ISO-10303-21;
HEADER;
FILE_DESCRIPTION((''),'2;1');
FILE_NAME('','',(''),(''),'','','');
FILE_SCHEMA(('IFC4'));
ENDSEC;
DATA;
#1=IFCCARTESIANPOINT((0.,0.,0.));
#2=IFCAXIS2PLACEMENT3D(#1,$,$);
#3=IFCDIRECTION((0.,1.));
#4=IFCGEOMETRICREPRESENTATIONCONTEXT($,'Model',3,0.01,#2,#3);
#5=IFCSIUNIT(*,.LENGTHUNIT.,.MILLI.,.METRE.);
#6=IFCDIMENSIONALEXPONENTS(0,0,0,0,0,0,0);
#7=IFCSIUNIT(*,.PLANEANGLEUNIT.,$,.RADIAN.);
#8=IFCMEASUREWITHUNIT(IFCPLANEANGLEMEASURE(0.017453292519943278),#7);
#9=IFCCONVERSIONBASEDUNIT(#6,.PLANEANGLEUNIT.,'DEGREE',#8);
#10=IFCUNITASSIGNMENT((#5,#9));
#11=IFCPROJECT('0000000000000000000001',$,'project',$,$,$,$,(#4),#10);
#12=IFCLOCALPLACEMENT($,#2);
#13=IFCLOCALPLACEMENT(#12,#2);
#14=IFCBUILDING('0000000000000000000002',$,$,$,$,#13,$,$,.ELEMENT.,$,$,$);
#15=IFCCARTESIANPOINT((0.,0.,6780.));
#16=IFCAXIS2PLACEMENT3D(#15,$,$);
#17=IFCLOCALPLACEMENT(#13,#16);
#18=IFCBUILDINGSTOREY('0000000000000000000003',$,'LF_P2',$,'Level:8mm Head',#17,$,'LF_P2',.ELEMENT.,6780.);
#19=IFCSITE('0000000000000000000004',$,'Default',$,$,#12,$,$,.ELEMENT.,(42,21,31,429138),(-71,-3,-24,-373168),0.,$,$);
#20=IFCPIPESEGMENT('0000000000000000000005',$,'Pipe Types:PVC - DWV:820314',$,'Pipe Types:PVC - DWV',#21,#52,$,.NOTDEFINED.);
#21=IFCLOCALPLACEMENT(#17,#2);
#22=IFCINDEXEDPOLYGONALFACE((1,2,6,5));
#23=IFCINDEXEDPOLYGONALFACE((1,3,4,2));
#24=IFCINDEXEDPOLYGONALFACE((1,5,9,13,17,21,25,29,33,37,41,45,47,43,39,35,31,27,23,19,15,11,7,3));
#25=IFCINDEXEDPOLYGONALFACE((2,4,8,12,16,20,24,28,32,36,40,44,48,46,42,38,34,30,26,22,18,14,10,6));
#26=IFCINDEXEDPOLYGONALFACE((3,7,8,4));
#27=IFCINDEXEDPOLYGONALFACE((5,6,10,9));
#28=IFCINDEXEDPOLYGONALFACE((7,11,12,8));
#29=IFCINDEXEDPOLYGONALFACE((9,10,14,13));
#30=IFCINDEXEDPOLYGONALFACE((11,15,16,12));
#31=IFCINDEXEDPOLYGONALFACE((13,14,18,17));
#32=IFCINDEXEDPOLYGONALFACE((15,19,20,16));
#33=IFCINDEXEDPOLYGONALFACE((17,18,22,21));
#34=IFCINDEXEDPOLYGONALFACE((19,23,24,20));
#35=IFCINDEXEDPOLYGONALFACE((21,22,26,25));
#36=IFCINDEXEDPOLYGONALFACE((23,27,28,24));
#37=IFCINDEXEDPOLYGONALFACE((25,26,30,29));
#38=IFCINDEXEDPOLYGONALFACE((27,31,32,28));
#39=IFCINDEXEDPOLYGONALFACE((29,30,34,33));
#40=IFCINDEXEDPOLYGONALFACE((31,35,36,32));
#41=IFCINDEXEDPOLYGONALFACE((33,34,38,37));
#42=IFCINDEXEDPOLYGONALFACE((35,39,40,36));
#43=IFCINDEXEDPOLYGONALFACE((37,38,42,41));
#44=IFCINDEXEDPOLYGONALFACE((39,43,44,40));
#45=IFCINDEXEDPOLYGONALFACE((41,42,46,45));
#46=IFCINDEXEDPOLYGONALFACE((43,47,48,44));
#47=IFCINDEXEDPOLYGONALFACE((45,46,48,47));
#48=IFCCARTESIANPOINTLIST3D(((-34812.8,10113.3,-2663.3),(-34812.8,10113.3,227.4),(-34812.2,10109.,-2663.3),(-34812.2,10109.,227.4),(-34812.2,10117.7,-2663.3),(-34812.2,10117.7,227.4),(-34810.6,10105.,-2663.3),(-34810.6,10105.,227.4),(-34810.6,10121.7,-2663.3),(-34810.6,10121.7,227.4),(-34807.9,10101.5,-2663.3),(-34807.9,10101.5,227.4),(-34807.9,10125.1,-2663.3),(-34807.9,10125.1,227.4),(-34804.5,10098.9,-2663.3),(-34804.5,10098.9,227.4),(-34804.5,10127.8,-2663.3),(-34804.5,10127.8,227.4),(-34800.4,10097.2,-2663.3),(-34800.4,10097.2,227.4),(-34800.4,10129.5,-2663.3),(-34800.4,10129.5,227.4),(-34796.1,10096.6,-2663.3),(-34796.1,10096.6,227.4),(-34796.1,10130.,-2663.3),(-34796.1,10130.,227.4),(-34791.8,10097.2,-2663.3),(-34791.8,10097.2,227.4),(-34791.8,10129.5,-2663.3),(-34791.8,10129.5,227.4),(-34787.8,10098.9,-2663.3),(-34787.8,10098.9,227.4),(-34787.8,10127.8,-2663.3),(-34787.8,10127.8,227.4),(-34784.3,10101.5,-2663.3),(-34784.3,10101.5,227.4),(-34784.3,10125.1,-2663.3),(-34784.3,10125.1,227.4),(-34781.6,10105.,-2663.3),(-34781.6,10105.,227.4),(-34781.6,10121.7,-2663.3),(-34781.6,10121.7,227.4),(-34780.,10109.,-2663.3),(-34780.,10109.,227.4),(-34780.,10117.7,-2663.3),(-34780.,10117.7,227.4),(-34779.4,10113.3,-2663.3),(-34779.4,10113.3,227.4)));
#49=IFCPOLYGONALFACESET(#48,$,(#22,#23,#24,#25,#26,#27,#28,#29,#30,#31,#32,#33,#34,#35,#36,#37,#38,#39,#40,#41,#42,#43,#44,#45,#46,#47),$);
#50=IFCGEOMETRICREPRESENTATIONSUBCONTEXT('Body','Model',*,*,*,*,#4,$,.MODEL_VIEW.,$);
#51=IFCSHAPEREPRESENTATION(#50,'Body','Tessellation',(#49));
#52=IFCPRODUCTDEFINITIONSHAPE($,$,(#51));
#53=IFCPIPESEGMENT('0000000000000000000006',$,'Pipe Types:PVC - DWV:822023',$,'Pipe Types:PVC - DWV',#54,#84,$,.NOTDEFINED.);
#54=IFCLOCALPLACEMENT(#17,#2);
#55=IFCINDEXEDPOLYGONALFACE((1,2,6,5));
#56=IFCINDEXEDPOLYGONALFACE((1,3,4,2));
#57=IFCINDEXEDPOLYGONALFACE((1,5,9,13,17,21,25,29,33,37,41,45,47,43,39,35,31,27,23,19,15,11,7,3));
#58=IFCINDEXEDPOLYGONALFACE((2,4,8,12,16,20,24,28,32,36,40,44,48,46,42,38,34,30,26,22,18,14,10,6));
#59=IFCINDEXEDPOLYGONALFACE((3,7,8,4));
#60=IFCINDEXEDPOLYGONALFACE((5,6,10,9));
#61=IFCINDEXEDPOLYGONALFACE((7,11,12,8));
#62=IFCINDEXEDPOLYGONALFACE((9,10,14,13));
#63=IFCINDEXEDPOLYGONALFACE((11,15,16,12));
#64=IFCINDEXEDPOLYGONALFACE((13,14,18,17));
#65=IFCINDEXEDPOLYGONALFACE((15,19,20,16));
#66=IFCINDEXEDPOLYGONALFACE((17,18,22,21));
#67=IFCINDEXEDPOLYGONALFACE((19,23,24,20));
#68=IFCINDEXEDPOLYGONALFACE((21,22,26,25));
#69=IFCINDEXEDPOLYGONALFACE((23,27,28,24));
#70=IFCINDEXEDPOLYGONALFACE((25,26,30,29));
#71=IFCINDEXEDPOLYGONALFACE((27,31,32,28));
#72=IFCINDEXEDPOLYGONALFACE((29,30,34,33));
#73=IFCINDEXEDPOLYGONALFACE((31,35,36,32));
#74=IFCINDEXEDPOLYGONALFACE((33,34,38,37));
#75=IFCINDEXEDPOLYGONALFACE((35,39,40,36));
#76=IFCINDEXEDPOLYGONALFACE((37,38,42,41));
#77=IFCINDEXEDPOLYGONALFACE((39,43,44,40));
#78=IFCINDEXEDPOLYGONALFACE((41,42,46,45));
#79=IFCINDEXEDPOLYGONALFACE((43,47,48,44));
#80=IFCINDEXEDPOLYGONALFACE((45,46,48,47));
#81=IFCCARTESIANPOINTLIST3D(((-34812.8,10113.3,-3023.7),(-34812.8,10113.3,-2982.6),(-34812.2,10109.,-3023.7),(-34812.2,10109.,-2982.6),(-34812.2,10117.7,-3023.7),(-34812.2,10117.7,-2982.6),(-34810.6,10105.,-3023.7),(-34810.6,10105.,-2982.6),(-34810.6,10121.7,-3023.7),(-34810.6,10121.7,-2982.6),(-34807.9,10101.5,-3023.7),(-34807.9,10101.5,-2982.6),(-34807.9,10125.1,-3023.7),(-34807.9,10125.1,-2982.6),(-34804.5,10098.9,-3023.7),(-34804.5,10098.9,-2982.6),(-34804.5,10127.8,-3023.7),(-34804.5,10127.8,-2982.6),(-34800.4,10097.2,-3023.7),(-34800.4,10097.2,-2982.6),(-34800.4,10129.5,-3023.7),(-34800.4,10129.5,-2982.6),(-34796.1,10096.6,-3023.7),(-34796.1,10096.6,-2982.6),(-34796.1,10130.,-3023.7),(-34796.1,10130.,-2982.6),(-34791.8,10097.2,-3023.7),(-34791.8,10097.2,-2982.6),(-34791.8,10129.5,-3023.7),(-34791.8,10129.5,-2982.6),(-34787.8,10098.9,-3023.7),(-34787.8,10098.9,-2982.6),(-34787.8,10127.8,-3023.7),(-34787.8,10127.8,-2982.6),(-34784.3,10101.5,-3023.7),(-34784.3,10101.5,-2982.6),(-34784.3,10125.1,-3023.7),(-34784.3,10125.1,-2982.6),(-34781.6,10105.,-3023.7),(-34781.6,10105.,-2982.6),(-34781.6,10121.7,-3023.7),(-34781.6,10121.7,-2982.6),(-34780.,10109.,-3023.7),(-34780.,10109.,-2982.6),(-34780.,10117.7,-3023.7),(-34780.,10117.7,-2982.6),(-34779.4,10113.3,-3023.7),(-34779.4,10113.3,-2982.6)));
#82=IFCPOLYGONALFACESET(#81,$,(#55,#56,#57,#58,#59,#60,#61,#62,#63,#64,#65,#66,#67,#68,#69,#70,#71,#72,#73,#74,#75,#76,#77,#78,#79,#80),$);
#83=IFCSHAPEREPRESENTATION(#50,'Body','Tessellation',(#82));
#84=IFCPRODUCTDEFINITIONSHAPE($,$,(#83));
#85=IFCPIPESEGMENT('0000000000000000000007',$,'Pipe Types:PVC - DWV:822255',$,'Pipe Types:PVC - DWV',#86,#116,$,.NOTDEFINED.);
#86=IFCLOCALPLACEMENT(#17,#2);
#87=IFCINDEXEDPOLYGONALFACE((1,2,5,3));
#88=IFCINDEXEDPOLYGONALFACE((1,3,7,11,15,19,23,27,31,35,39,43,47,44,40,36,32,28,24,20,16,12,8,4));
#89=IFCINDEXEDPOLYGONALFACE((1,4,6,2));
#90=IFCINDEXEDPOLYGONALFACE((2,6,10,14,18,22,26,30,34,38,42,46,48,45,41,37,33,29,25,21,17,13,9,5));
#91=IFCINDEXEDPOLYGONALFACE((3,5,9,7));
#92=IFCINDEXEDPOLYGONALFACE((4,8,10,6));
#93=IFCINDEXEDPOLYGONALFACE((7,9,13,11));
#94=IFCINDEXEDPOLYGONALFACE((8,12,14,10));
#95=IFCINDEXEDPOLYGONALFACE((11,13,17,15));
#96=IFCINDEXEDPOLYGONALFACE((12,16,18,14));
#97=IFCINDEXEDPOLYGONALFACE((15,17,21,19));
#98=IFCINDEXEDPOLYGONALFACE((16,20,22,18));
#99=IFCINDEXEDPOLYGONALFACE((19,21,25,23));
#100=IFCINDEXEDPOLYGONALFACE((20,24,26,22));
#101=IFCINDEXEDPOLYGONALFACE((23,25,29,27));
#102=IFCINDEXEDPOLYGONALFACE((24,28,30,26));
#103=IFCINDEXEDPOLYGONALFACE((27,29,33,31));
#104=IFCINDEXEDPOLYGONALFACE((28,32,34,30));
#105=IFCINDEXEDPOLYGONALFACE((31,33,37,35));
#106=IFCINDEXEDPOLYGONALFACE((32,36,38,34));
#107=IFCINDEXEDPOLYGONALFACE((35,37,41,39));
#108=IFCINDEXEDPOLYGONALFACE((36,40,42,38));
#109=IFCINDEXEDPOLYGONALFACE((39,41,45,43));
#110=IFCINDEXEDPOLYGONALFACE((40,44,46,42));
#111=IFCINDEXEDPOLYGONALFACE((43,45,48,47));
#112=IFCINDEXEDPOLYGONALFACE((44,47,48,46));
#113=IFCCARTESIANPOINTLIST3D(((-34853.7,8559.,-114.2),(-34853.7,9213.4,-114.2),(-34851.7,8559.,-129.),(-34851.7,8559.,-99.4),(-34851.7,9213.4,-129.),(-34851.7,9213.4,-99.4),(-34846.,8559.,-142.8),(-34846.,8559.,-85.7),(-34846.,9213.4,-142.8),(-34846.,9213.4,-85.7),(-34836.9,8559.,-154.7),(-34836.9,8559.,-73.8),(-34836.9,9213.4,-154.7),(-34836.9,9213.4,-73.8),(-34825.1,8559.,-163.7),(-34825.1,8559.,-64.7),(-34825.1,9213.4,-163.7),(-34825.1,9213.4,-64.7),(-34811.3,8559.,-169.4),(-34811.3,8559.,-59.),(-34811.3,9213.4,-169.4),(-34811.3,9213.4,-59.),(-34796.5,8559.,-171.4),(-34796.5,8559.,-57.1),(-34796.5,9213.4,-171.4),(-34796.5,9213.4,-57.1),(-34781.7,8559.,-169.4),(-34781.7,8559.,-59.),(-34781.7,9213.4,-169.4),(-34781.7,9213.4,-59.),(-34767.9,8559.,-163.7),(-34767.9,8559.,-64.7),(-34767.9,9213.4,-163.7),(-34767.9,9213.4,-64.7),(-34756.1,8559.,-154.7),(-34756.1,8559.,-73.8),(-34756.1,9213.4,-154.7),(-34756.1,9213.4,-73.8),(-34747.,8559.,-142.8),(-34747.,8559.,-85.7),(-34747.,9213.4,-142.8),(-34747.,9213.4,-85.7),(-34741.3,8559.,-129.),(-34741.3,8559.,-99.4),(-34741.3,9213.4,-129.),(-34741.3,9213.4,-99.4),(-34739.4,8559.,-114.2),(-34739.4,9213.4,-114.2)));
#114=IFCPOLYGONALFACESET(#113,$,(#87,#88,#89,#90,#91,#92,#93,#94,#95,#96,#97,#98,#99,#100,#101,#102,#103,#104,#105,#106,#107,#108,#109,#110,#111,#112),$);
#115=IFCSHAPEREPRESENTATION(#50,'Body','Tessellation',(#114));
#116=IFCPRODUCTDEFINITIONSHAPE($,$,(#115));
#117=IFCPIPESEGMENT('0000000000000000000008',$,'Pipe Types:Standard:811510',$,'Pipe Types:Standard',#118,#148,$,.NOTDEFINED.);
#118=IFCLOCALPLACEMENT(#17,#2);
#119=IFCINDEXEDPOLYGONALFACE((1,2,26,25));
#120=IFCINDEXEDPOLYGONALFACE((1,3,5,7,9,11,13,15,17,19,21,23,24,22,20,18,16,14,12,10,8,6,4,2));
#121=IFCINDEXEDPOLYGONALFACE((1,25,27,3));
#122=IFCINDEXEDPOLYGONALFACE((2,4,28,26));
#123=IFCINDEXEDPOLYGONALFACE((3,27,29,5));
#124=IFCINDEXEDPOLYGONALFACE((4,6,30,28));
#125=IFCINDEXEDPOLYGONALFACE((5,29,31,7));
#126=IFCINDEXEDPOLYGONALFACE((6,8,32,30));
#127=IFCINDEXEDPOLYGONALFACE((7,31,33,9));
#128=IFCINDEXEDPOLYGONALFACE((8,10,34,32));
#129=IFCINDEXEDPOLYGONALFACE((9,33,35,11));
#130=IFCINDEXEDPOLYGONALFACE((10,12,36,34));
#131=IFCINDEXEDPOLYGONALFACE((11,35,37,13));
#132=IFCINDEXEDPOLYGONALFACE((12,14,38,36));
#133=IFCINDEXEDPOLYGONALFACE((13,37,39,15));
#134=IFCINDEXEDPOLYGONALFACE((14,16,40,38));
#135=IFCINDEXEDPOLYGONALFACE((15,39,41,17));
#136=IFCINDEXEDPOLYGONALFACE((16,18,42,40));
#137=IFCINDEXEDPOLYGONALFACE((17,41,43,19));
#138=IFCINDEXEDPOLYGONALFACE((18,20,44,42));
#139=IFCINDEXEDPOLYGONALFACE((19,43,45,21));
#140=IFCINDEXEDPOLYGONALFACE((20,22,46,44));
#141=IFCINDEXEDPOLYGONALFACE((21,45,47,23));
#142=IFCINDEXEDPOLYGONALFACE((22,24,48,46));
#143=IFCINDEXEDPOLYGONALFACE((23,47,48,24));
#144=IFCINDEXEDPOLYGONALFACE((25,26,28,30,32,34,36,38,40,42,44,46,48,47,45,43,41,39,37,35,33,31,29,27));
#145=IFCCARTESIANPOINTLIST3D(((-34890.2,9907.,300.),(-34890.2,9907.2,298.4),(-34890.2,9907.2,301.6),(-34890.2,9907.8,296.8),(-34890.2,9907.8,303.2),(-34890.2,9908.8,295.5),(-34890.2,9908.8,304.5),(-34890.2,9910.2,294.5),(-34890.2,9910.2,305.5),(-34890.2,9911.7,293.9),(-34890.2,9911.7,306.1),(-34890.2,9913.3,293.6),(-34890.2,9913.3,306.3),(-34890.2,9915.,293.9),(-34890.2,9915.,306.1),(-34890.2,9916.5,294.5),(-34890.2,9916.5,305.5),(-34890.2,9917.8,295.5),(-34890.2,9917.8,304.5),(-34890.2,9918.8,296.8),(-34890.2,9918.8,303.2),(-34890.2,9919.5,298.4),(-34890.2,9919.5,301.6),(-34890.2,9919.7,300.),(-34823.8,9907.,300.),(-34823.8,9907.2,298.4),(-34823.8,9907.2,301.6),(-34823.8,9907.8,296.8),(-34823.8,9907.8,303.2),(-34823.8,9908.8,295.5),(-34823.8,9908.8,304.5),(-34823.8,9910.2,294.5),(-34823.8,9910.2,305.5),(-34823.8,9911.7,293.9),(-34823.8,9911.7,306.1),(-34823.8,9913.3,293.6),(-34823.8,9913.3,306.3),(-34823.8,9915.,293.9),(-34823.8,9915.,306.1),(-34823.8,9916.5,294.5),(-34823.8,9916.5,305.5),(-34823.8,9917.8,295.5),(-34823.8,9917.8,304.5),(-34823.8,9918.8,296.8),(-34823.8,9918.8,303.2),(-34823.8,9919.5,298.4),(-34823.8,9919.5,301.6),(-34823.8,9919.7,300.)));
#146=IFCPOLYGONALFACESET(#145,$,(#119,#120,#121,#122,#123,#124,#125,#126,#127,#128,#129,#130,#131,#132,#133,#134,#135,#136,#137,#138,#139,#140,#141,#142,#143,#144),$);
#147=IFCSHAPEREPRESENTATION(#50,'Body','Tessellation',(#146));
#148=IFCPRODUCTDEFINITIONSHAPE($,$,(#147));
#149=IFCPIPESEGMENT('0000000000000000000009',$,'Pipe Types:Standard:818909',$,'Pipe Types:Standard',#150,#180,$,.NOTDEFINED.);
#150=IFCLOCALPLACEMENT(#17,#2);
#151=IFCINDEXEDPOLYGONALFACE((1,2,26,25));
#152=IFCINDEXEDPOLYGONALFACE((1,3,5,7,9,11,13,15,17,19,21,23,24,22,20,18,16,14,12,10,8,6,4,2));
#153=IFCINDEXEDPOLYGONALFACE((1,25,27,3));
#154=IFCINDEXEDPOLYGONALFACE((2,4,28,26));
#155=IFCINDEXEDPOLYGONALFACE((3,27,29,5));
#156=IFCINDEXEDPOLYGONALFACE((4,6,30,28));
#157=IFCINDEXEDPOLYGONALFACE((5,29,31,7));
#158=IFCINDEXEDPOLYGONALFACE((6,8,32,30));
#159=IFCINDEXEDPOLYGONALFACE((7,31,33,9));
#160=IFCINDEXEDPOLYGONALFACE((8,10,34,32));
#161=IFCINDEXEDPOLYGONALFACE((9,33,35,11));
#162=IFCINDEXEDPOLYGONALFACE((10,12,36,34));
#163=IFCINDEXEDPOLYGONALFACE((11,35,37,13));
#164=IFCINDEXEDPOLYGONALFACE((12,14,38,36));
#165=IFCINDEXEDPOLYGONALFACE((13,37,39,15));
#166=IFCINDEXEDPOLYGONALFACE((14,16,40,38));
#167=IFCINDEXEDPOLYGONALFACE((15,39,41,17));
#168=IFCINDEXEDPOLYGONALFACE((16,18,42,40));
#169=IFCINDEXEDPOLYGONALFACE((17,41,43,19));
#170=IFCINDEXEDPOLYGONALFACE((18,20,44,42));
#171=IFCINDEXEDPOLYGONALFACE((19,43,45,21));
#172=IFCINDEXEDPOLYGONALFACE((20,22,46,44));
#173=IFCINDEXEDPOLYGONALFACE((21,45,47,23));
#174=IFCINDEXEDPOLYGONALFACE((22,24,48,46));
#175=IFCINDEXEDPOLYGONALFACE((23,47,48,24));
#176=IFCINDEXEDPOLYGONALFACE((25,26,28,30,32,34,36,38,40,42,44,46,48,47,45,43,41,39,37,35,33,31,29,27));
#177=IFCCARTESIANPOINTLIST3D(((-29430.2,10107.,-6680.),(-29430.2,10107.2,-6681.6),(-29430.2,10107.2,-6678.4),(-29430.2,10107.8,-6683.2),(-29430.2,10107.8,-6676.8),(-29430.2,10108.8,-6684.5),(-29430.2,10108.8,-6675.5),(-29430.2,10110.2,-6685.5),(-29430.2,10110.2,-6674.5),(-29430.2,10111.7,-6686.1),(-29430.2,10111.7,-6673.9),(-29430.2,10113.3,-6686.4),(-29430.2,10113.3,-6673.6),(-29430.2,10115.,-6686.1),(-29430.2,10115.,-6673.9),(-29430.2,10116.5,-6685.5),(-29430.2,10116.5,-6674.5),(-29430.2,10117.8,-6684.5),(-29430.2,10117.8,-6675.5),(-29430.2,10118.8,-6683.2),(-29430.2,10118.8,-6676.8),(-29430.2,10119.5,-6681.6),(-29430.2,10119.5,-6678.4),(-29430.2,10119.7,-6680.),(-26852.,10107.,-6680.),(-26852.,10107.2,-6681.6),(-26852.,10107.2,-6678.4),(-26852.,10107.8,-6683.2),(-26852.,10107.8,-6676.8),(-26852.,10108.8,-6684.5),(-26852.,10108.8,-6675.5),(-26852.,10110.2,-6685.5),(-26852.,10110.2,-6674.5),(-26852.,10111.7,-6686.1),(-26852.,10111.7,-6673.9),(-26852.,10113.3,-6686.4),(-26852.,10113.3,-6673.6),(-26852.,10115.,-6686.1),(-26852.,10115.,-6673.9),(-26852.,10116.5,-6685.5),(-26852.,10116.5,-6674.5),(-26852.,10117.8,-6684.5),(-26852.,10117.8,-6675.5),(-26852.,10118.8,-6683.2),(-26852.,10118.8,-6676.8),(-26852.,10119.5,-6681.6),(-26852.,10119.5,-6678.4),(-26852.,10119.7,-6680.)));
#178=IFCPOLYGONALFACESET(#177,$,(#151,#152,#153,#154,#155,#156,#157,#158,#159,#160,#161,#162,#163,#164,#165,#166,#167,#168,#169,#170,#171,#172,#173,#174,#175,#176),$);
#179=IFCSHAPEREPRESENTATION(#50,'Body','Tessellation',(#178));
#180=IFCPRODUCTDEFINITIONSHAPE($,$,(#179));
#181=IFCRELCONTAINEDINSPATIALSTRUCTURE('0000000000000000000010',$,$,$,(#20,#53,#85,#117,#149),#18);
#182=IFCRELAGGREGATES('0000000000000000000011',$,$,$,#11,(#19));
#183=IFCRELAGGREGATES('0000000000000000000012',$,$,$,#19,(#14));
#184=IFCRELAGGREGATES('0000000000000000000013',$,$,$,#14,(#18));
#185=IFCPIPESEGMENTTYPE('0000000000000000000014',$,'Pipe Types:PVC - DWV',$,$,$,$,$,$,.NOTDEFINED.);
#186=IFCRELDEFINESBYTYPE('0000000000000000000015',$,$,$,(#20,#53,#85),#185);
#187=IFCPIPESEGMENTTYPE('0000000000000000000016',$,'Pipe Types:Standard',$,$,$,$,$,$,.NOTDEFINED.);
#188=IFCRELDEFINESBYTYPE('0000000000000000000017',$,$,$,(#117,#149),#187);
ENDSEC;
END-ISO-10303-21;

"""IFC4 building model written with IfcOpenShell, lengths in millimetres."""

from ifc_helpers import new_model, entity, si_unit, converted_unit, direction, frame, origin, place, context, subcontext, project, spatial, arc, indexed_curve, outline, extrude, type_object, element, save


model = new_model("IFC4")

# Units and contexts
model_context = context("Model", 3, precision=0.01, world=origin(), true_north=direction((0.0, 1.0)))
body_context = subcontext(model_context, "Body", "Model", "MODEL_VIEW")
ifc_project = project(units=[si_unit("LENGTHUNIT", "METRE", prefix="MILLI"), converted_unit("PLANEANGLEUNIT", "DEGREE", entity("IfcPlaneAngleMeasure", 0.017453292519943278), si_unit("PLANEANGLEUNIT", "RADIAN"), dimensions=[0, 0, 0, 0, 0, 0, 0])], contexts=[model_context])

# Site, building, storey
site_placement = place(None, origin())
site = spatial("IfcSite", under=ifc_project, at=site_placement, Name="Default", CompositionType="ELEMENT", RefLatitude=(42, 21, 31, 429138), RefLongitude=(-71, -3, -24, -373168), RefElevation=0.0)
building_placement = place(site_placement, origin())
building = spatial("IfcBuilding", under=site, at=building_placement, CompositionType="ELEMENT")
storey_placement = place(building_placement, frame((0.0, 0.0, 6780.0)))
storey = spatial("IfcBuildingStorey", under=building, at=storey_placement, Name="LF_P2", ObjectType="Level:8mm Head", LongName="LF_P2", CompositionType="ELEMENT", Elevation=6780.0)

# Pipe segments
pipe_segment_type_1 = type_object("IfcPipeSegmentType", Name="Pipe Types:PVC - DWV", PredefinedType="NOTDEFINED")
pipe_segment_1_placement = place(storey_placement, origin())
element("IfcPipeSegment", 1, at=pipe_segment_1_placement, inside=storey, type_object=pipe_segment_type_1, Name="Pipe Types:PVC - DWV:820314", ObjectType="Pipe Types:PVC - DWV", PredefinedType="NOTDEFINED", context=body_context, shape_type="SweptSolid", body=[
    extrude(outline(indexed_curve([(16.7, 0.0), (11.8, 11.8), (0.0, 16.7), (-11.8, 11.8), (-16.7, 0.0), (-11.8, -11.8), (0.0, -16.7), (11.8, -11.8)], segments=[arc(1, 2, 3), arc(3, 4, 5), arc(5, 6, 7), arc(7, 8, 1)], self_intersect=False)), frame((-34796.1, 10113.3, -2663.3)), (0.0, 0.0, 1.0), 2890.7),
])
pipe_segment_2_placement = place(storey_placement, origin())
element("IfcPipeSegment", 2, at=pipe_segment_2_placement, inside=storey, type_object=pipe_segment_type_1, Name="Pipe Types:PVC - DWV:822023", ObjectType="Pipe Types:PVC - DWV", PredefinedType="NOTDEFINED", context=body_context, shape_type="SweptSolid", body=[
    extrude(outline(indexed_curve([(16.7, 0.0), (11.8, 11.8), (0.0, 16.7), (-11.8, 11.8), (-16.7, 0.0), (-11.8, -11.8), (0.0, -16.7), (11.8, -11.8)], segments=[arc(1, 2, 3), arc(3, 4, 5), arc(5, 6, 7), arc(7, 8, 1)], self_intersect=False)), frame((-34796.1, 10113.3, -3023.7)), (0.0, 0.0, 1.0), 41.1),
])
pipe_segment_3_placement = place(storey_placement, origin())
element("IfcPipeSegment", 3, at=pipe_segment_3_placement, inside=storey, type_object=pipe_segment_type_1, Name="Pipe Types:PVC - DWV:822255", ObjectType="Pipe Types:PVC - DWV", PredefinedType="NOTDEFINED", context=body_context, shape_type="SweptSolid", body=[
    extrude(outline(indexed_curve([(57.2, 0.0), (40.4, 40.4), (0.0, 57.2), (-40.4, 40.4), (-57.2, 0.0), (-40.4, -40.4), (0.0, -57.2), (40.4, -40.4)], segments=[arc(1, 2, 3), arc(3, 4, 5), arc(5, 6, 7), arc(7, 8, 1)], self_intersect=False)), frame((-34796.5, 8559.0, -114.2), z_axis=(0.0, 1.0, 0.0), x_axis=(1.0, 0.0, 0.0)), (0.0, 0.0, 1.0), 654.5),
])
pipe_segment_type_2 = type_object("IfcPipeSegmentType", Name="Pipe Types:Standard", PredefinedType="NOTDEFINED")
pipe_segment_4_placement = place(storey_placement, origin())
element("IfcPipeSegment", 4, at=pipe_segment_4_placement, inside=storey, type_object=pipe_segment_type_2, Name="Pipe Types:Standard:811510", ObjectType="Pipe Types:Standard", PredefinedType="NOTDEFINED", context=body_context, shape_type="SweptSolid", body=[
    extrude(outline(indexed_curve([(6.3, 0.0), (4.5, 4.5), (0.0, 6.3), (-4.5, 4.5), (-6.4, 0.0), (-4.5, -4.5), (0.0, -6.4), (4.5, -4.5)], segments=[arc(1, 2, 3), arc(3, 4, 5), arc(5, 6, 7), arc(7, 8, 1)], self_intersect=False)), frame((-34890.2, 9913.3, 300.0), z_axis=(1.0, 0.0, 0.0), x_axis=(0.0, 1.0, 0.0)), (0.0, 0.0, 1.0), 66.4),
])
pipe_segment_5_placement = place(storey_placement, origin())
element("IfcPipeSegment", 5, at=pipe_segment_5_placement, inside=storey, type_object=pipe_segment_type_2, Name="Pipe Types:Standard:818909", ObjectType="Pipe Types:Standard", PredefinedType="NOTDEFINED", context=body_context, shape_type="SweptSolid", body=[
    extrude(outline(indexed_curve([(6.4, 0.0), (4.5, 4.5), (0.0, 6.3), (-4.5, 4.5), (-6.4, 0.0), (-4.5, -4.5), (0.0, -6.3), (4.5, -4.5)], segments=[arc(1, 2, 3), arc(3, 4, 5), arc(5, 6, 7), arc(7, 8, 1)], self_intersect=False)), frame((-29430.2, 10113.3, -6680.0), z_axis=(1.0, 0.0, 0.0), x_axis=(0.0, 1.0, 0.0)), (0.0, 0.0, 1.0), 2578.2),
])

save(model, "model.ifc")
